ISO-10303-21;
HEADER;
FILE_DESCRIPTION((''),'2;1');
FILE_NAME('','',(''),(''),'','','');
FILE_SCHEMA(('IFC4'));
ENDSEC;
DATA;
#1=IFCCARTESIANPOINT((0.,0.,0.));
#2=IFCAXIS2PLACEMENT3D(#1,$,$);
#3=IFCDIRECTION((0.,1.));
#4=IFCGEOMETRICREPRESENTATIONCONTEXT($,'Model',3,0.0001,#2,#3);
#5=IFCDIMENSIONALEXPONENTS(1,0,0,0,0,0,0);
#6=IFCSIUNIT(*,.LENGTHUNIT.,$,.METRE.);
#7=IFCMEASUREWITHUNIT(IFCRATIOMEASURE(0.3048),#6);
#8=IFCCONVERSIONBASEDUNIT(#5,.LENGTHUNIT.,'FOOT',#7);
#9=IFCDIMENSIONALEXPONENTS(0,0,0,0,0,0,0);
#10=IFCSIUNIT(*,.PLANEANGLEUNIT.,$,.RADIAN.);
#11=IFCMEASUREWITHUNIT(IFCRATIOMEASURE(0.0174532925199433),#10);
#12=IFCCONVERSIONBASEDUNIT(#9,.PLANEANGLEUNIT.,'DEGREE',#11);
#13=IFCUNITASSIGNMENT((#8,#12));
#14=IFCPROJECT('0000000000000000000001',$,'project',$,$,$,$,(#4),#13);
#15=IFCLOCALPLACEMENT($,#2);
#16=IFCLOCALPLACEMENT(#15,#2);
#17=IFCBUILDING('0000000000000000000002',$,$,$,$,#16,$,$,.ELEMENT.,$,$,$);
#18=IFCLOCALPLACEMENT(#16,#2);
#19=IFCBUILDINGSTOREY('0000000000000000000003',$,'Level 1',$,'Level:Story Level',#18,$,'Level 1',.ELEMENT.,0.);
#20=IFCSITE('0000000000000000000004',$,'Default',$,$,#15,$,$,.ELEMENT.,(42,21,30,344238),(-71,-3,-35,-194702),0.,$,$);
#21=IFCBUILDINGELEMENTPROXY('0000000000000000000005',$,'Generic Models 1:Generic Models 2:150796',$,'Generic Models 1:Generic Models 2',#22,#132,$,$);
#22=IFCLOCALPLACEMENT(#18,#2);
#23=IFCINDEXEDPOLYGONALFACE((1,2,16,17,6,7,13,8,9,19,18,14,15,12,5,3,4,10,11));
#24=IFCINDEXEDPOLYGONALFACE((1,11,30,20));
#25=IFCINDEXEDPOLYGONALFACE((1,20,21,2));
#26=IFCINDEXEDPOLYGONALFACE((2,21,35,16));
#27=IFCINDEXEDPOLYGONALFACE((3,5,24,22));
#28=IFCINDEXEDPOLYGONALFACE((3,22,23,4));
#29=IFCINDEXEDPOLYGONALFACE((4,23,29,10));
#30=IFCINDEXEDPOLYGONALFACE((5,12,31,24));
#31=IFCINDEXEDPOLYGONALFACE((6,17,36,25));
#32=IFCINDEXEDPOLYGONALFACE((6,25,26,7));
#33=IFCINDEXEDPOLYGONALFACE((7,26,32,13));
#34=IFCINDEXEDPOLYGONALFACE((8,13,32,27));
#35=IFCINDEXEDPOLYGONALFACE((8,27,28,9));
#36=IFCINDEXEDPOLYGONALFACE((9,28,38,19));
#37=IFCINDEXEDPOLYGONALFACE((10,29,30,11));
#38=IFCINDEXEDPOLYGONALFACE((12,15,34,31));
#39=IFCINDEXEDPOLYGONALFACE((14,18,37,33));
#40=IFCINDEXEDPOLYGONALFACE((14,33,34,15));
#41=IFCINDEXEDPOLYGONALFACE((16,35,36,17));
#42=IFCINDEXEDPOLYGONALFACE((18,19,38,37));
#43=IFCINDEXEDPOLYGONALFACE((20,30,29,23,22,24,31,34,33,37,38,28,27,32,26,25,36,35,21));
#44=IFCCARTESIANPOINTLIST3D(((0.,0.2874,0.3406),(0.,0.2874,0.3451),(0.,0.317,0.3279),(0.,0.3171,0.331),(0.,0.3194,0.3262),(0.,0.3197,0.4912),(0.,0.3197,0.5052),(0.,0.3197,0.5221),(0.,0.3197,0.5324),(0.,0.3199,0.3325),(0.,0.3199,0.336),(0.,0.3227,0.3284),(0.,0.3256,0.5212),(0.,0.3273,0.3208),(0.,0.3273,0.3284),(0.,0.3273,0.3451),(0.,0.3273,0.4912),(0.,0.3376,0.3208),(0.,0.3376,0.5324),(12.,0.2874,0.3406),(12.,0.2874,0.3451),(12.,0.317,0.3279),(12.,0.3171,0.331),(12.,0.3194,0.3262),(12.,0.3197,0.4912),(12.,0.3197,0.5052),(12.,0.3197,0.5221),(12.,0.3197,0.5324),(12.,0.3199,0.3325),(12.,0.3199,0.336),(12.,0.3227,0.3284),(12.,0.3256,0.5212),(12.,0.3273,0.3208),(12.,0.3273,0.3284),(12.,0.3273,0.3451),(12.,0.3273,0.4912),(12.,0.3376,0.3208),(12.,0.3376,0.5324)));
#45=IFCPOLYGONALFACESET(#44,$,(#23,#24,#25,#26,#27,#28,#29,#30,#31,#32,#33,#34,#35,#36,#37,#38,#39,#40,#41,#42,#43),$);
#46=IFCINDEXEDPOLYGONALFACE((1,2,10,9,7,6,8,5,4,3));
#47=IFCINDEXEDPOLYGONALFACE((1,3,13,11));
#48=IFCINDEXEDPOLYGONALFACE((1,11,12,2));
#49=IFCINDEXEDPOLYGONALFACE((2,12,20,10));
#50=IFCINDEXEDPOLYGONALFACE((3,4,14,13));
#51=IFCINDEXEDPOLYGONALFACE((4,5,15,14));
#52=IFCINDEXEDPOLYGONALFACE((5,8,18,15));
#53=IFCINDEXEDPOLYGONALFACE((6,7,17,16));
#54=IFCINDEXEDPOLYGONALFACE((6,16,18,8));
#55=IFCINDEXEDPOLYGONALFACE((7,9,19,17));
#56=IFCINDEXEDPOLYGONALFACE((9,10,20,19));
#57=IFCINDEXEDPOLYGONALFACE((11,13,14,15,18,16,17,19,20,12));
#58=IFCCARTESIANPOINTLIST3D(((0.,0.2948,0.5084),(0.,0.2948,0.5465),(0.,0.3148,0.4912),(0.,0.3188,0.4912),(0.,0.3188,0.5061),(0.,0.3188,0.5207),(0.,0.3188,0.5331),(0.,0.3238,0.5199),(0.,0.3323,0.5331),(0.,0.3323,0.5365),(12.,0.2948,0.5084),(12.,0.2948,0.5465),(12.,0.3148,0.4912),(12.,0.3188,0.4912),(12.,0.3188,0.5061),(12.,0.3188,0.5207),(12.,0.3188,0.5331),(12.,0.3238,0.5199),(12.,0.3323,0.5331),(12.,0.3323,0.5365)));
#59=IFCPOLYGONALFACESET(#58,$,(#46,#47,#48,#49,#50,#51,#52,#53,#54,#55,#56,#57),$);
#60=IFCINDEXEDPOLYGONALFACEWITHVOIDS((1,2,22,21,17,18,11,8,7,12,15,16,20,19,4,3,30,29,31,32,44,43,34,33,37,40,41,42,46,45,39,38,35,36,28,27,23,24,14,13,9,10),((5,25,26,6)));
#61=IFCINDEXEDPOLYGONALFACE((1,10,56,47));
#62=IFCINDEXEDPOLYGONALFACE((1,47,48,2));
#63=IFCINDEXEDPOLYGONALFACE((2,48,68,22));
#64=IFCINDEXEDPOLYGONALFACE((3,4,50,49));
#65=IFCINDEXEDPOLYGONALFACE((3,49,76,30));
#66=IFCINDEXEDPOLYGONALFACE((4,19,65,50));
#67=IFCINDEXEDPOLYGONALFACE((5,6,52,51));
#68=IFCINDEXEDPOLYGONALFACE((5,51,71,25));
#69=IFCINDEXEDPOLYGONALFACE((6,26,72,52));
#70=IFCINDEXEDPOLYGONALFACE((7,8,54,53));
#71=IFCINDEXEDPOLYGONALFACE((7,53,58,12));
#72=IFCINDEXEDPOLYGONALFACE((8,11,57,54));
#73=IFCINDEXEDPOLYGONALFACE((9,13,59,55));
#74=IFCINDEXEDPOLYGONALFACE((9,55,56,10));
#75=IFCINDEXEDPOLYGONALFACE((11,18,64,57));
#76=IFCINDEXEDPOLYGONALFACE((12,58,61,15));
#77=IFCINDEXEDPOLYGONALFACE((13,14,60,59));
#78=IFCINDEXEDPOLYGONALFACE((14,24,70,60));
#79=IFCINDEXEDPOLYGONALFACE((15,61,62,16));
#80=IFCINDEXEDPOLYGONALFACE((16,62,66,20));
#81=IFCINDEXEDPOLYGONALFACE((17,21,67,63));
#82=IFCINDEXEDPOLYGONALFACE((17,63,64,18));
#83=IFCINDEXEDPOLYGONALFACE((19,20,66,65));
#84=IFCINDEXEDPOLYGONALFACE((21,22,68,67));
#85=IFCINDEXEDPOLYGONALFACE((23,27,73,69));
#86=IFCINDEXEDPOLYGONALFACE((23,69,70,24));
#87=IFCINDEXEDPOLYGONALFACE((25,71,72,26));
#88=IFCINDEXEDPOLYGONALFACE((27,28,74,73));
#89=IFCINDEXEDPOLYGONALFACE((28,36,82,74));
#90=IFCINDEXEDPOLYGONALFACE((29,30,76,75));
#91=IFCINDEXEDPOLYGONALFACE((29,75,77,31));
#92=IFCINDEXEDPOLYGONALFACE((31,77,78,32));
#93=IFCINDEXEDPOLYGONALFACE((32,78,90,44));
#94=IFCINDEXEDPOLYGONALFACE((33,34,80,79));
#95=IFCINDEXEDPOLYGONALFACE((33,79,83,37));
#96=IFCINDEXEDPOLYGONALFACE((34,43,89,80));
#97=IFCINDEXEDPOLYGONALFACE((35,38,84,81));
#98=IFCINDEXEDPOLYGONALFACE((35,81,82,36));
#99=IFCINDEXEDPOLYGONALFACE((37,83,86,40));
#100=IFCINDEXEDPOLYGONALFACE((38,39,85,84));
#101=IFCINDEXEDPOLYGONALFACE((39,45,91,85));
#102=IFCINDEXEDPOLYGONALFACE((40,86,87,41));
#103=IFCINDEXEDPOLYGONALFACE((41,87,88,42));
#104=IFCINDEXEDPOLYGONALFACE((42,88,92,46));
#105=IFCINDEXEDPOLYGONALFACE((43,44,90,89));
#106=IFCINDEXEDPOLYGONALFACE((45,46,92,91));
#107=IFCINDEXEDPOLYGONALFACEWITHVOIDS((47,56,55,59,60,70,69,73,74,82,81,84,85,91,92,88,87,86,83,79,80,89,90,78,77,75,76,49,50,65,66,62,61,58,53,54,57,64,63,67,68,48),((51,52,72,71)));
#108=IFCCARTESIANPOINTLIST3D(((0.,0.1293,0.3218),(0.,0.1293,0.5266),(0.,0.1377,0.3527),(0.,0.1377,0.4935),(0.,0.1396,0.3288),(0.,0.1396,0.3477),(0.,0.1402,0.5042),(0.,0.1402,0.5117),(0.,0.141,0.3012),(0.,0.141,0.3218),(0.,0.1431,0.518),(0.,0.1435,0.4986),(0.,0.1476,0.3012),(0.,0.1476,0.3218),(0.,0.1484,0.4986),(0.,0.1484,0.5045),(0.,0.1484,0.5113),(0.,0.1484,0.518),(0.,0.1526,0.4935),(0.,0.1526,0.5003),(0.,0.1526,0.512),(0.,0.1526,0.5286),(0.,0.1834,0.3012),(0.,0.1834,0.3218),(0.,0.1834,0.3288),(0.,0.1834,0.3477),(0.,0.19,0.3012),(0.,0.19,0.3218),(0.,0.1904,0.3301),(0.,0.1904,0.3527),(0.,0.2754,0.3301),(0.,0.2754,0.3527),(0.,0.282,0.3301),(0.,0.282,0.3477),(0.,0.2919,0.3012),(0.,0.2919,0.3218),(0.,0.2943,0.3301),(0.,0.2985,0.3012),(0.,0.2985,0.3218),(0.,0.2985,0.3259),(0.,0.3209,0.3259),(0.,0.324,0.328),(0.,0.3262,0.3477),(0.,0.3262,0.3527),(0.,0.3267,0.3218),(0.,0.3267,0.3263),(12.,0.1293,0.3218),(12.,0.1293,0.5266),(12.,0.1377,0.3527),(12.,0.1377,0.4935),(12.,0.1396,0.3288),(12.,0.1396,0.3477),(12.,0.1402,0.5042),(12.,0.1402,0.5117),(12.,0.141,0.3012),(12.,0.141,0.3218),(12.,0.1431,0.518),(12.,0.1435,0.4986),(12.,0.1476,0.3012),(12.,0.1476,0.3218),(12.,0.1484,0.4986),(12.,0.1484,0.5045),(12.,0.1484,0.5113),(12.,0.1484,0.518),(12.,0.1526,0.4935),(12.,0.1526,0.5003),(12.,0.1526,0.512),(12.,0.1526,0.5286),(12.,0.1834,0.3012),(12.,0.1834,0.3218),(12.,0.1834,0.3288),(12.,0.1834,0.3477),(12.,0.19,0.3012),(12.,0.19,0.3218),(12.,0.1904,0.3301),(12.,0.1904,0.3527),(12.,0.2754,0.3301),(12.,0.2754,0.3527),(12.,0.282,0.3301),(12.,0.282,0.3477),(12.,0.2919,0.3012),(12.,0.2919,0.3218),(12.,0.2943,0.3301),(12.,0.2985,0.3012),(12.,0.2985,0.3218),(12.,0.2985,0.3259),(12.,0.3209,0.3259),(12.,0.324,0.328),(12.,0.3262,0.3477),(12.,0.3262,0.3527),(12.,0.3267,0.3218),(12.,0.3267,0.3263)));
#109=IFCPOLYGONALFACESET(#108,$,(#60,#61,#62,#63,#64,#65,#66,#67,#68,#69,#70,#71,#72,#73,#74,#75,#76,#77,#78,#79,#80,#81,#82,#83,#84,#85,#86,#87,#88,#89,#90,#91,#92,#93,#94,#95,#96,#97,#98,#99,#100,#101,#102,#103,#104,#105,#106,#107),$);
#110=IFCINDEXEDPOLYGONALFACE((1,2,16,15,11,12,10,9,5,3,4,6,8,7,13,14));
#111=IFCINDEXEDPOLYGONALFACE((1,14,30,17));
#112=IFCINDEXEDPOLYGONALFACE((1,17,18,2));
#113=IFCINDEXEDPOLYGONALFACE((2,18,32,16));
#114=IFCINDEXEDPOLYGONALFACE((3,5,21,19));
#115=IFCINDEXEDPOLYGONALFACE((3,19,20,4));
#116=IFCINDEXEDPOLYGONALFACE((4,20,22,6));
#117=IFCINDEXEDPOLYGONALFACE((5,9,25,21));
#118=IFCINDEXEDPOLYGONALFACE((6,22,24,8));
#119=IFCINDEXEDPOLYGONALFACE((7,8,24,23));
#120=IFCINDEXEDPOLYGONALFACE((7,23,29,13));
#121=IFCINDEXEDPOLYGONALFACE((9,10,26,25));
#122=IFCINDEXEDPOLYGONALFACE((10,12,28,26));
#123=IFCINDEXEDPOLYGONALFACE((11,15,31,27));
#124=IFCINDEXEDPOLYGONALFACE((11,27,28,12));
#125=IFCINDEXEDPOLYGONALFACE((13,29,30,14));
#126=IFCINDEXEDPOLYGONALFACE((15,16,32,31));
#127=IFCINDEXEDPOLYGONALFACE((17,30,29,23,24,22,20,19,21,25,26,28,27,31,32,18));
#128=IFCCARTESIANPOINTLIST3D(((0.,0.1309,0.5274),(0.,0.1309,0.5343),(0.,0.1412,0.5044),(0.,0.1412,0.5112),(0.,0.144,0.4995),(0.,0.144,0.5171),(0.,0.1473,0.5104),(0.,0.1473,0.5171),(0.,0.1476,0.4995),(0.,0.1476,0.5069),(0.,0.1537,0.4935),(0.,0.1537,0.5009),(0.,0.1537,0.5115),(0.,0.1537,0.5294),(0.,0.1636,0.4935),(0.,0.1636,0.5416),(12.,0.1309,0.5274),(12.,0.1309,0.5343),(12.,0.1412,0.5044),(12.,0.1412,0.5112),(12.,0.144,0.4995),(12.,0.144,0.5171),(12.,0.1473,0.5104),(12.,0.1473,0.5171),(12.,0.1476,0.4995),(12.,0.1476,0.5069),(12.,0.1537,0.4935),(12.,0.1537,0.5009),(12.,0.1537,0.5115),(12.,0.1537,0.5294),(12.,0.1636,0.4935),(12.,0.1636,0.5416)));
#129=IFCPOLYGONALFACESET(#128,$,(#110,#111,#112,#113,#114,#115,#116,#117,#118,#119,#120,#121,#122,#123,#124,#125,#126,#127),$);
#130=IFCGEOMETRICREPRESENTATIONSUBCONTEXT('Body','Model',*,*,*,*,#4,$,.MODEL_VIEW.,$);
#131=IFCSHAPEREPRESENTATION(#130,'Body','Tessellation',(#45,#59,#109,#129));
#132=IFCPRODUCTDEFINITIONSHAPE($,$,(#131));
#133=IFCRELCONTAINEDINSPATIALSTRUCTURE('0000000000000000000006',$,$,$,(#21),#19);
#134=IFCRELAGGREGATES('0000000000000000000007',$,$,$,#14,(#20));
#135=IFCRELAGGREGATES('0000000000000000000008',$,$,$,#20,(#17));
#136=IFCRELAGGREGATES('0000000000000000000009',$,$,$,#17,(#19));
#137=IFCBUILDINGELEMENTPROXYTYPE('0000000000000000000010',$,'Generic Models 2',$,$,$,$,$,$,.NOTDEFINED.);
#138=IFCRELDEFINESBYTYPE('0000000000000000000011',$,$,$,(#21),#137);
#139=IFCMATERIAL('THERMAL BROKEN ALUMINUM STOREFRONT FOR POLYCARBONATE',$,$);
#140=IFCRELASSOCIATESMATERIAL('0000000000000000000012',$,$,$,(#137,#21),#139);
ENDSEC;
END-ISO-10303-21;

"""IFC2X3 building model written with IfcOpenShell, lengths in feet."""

from ifc_helpers import new_model, entity, si_unit, converted_unit, direction, frame, origin, place, context, subcontext, project, spatial, polyline, outline, extrude, source, transform, mapped, material, type_object, type_shapes, element, save


model = new_model("IFC2X3")

# Units and contexts
model_context = context("Model", 3, precision=0.0001, world=origin(), true_north=direction((0.0, 1.0)))
body_context = subcontext(model_context, "Body", "Model", "MODEL_VIEW")
ifc_project = project(units=[converted_unit("LENGTHUNIT", "FOOT", entity("IfcRatioMeasure", 0.3048), si_unit("LENGTHUNIT", "METRE"), dimensions=[1, 0, 0, 0, 0, 0, 0]), converted_unit("PLANEANGLEUNIT", "DEGREE", entity("IfcRatioMeasure", 0.0174532925199433), si_unit("PLANEANGLEUNIT", "RADIAN"), dimensions=[0, 0, 0, 0, 0, 0, 0])], contexts=[model_context])

# Site, building, storey
site_placement = place(None, origin())
site = spatial("IfcSite", under=ifc_project, at=site_placement, Name="Default", CompositionType="ELEMENT", RefLatitude=(42, 21, 30, 344238), RefLongitude=(-71, -3, -35, -194702), RefElevation=0.0)
building_placement = place(site_placement, origin())
building = spatial("IfcBuilding", under=site, at=building_placement, CompositionType="ELEMENT")
storey_placement = place(building_placement, origin())
storey = spatial("IfcBuildingStorey", under=building, at=storey_placement, Name="Level 1", ObjectType="Level:Story Level", LongName="Level 1", CompositionType="ELEMENT", Elevation=0.0)

# Building element proxy
ifc_material = material(Name="THERMAL BROKEN ALUMINUM STOREFRONT FOR POLYCARBONATE")
building_element_proxy_type_1 = type_object("IfcBuildingElementProxyType", Name="Generic Models 2", PredefinedType="NOTDEFINED", material=ifc_material)
shared_shape_1 = source(origin(), body_context, "Body", "SweptSolid", [
    extrude(outline(polyline([(0.068, 0.0006), (0.0711, 0.0006), (0.0726, 0.0031), (0.0702, 0.0064), (0.07, 0.011), (0.0776, 0.0114), (0.0771, 0.0217), (-0.1343, 0.0107), (-0.1334, -0.0072), (-0.1231, -0.0066), (-0.1224, -0.0008), (-0.1062, -0.0058), (-0.0922, -0.005), (-0.0926, 0.0025), (0.0533, 0.0101), (0.0554, -0.0297), (0.0599, -0.0295), (0.0628, 0.0032), (0.0663, 0.0034), (0.068, 0.0006)])), frame((0.0, 0.32, 0.0977), z_axis=(1.0, 0.0, 0.0), x_axis=(0.0, -0.051774, -0.998659)), (0.0, 0.0, 1.0), 12.0),
    extrude(outline(polyline([(-0.0104, -0.0212), (0.0284, -0.0212), (0.0186, 0.0156), (-0.0052, 0.0271), (-0.009, 0.026), (-0.0051, 0.0117), (-0.0065, -0.003), (-0.0014, -0.0025), (0.0018, -0.0144), (-0.0113, -0.0179), (-0.0104, -0.0212)])), frame((0.0, 0.3168, 0.2175), z_axis=(1.0, 0.0, 0.0), x_axis=(0.0, -0.966235, 0.257663)), (0.0, 0.0, 1.0), 12.0),
    extrude(outline(polyline([(-0.073, 0.107), (-0.058, 0.107), (-0.058, 0.1137), (-0.0623, 0.118), (-0.0623, 0.1121), (-0.0672, 0.1121), (-0.0704, 0.1177), (-0.0704, 0.1252), (-0.0675, 0.1315), (-0.0623, 0.1315), (-0.0623, 0.1248), (-0.058, 0.1255), (-0.058, 0.142), (-0.0814, 0.1401), (-0.0814, -0.0647), (-0.0697, -0.0647), (-0.0697, -0.0853), (-0.0631, -0.0853), (-0.0631, -0.0647), (-0.0273, -0.0647), (-0.0273, -0.0853), (-0.0207, -0.0853), (-0.0207, -0.0647), (0.0812, -0.0647), (0.0812, -0.0853), (0.0878, -0.0853), (0.0878, -0.0647), (0.1161, -0.0647), (0.1161, -0.0603), (0.1133, -0.0585), (0.1102, -0.0606), (0.0878, -0.0606), (0.0836, -0.0564), (0.0713, -0.0564), (0.0713, -0.0389), (0.1155, -0.0389), (0.1155, -0.0338), (0.0647, -0.0338), (0.0647, -0.0564), (-0.0203, -0.0564), (-0.0203, -0.0338), (-0.073, -0.0338), (-0.073, 0.107)]), holes=[polyline([(-0.0711, -0.0577), (-0.0711, -0.0389), (-0.0273, -0.0389), (-0.0273, -0.0577), (-0.0711, -0.0577)])]), frame((0.0, 0.2107, 0.0853), z_axis=(1.0, 0.0, 0.0), x_axis=(0.0, 1.0, 0.0)), (0.0, 0.0, 1.0), 12.0),
    extrude(outline(polyline([(-0.0218, -0.0251), (0.0116, -0.0251), (0.0131, -0.0183), (-0.0094, -0.0153), (-0.0056, 0.0021), (0.0008, 0.0018), (-0.0006, -0.0047), (0.0027, -0.0054), (0.0066, -0.0003), (0.0081, 0.0064), (0.0064, 0.0118), (0.0029, 0.0126), (0.0013, 0.0053), (-0.0032, 0.0125), (-0.0017, 0.0197), (-0.0114, 0.0218), (-0.0218, -0.0251)])), frame((0.0, 0.1478, 0.2112), z_axis=(1.0, 0.0, 0.0), x_axis=(0.0, -0.976068, -0.217466)), (0.0, 0.0, 1.0), 12.0),
])
type_shapes(building_element_proxy_type_1, [shared_shape_1])
proxy_1_placement = place(storey_placement, frame((0.0, 0.0, 0.3012)))
element("IfcBuildingElementProxy", 1, at=proxy_1_placement, inside=storey, type_object=building_element_proxy_type_1, material=ifc_material, Name="Generic Models 1:Generic Models 2:150796", ObjectType="Generic Models 1:Generic Models 2", context=body_context, shape_type="MappedRepresentation", body=[
    mapped(shared_shape_1, transform((0.0, 0.0, 0.0), scale=1.0)),
])

save(model, "model.ifc")
